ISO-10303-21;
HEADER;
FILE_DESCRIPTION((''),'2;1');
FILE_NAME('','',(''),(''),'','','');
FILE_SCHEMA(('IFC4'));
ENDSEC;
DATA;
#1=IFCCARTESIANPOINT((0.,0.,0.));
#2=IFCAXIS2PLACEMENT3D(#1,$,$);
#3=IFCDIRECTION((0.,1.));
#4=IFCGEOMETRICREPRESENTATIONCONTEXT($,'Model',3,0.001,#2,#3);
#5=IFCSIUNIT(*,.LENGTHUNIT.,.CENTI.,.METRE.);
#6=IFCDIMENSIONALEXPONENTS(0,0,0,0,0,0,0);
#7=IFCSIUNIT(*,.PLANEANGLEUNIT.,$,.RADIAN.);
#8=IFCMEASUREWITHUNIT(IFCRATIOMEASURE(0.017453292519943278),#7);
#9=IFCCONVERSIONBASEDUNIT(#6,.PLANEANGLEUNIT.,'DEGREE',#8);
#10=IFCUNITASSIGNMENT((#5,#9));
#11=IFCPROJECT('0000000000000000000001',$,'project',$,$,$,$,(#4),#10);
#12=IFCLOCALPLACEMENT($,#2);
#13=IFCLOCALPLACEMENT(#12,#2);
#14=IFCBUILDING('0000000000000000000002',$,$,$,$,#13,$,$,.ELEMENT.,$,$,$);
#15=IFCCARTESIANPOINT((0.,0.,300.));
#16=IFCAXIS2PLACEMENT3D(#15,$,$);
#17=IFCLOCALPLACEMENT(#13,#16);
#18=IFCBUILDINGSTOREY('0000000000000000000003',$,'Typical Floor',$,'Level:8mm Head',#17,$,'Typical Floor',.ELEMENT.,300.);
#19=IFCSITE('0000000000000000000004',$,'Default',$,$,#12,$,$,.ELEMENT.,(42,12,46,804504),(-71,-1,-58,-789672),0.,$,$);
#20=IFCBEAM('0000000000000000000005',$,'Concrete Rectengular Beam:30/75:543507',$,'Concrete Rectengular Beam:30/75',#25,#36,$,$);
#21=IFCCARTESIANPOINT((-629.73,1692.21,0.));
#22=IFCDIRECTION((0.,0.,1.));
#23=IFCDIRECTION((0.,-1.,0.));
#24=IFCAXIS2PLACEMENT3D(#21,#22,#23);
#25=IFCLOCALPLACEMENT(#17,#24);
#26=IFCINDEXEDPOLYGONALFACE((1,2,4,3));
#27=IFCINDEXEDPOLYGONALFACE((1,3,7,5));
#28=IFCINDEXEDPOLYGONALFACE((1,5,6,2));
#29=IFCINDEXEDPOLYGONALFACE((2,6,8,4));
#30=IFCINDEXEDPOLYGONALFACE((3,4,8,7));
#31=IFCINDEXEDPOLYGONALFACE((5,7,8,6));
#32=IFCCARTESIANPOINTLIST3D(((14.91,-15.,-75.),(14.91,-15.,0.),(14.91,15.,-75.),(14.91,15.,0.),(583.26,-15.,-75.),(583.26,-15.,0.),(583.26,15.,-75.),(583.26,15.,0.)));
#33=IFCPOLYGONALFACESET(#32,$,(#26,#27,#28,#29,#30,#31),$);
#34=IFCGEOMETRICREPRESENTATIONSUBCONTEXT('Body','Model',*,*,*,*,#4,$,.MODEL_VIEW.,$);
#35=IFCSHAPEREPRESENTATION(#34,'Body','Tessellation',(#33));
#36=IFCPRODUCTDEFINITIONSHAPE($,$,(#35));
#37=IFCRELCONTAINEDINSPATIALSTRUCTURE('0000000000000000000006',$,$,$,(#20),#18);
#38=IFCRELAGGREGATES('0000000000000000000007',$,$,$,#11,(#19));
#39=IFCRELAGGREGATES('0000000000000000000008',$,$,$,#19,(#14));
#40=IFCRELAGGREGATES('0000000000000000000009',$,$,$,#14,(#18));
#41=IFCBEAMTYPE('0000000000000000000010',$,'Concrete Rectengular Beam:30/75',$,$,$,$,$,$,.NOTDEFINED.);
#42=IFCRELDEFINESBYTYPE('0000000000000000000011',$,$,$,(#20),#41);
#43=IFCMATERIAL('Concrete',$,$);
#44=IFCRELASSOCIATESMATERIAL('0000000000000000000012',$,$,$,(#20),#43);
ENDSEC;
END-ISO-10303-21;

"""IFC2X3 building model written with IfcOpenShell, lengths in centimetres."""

from ifc_helpers import new_model, entity, si_unit, converted_unit, direction, frame, frame_2d, origin, place, context, subcontext, project, spatial, rectangle, extrude, material, type_object, element, save


model = new_model("IFC2X3")

# Units and contexts
model_context = context("Model", 3, precision=0.001, world=origin(), true_north=direction((0.0, 1.0)))
body_context = subcontext(model_context, "Body", "Model", "MODEL_VIEW")
ifc_project = project(units=[si_unit("LENGTHUNIT", "METRE", prefix="CENTI"), converted_unit("PLANEANGLEUNIT", "DEGREE", entity("IfcRatioMeasure", 0.017453292519943278), si_unit("PLANEANGLEUNIT", "RADIAN"), dimensions=[0, 0, 0, 0, 0, 0, 0])], contexts=[model_context])

# Site, building, storey
site_placement = place(None, origin())
site = spatial("IfcSite", under=ifc_project, at=site_placement, Name="Default", CompositionType="ELEMENT", RefLatitude=(42, 12, 46, 804504), RefLongitude=(-71, -1, -58, -789672), RefElevation=0.0)
building_placement = place(site_placement, origin())
building = spatial("IfcBuilding", under=site, at=building_placement, CompositionType="ELEMENT")
storey_placement = place(building_placement, frame((0.0, 0.0, 300.0)))
storey = spatial("IfcBuildingStorey", under=building, at=storey_placement, Name="Typical Floor", ObjectType="Level:8mm Head", LongName="Typical Floor", CompositionType="ELEMENT", Elevation=300.0)

# Beam
ifc_material = material(Name="Concrete")
beam_type_1 = type_object("IfcBeamType", Name="Concrete Rectengular Beam:30/75", PredefinedType="NOTDEFINED")
beam_1_placement = place(storey_placement, frame((-629.73, 1692.21, 0.0), z_axis=(0.0, 0.0, 1.0), x_axis=(0.0, -1.0, 0.0)))
element("IfcBeam", 1, at=beam_1_placement, inside=storey, type_object=beam_type_1, material=ifc_material, Name="Concrete Rectengular Beam:30/75:543507", ObjectType="Concrete Rectengular Beam:30/75", context=body_context, shape_type="SweptSolid", body=[
    extrude(rectangle(XDim=75.0, YDim=30.0, at=frame_2d((0.0, 0.0), x_axis=(1.0, 0.0))), frame((14.91, 0.0, -37.5), z_axis=(1.0, 0.0, 0.0), x_axis=(0.0, 0.0, -1.0)), (0.0, 0.0, 1.0), 568.35),
])

save(model, "model.ifc")
